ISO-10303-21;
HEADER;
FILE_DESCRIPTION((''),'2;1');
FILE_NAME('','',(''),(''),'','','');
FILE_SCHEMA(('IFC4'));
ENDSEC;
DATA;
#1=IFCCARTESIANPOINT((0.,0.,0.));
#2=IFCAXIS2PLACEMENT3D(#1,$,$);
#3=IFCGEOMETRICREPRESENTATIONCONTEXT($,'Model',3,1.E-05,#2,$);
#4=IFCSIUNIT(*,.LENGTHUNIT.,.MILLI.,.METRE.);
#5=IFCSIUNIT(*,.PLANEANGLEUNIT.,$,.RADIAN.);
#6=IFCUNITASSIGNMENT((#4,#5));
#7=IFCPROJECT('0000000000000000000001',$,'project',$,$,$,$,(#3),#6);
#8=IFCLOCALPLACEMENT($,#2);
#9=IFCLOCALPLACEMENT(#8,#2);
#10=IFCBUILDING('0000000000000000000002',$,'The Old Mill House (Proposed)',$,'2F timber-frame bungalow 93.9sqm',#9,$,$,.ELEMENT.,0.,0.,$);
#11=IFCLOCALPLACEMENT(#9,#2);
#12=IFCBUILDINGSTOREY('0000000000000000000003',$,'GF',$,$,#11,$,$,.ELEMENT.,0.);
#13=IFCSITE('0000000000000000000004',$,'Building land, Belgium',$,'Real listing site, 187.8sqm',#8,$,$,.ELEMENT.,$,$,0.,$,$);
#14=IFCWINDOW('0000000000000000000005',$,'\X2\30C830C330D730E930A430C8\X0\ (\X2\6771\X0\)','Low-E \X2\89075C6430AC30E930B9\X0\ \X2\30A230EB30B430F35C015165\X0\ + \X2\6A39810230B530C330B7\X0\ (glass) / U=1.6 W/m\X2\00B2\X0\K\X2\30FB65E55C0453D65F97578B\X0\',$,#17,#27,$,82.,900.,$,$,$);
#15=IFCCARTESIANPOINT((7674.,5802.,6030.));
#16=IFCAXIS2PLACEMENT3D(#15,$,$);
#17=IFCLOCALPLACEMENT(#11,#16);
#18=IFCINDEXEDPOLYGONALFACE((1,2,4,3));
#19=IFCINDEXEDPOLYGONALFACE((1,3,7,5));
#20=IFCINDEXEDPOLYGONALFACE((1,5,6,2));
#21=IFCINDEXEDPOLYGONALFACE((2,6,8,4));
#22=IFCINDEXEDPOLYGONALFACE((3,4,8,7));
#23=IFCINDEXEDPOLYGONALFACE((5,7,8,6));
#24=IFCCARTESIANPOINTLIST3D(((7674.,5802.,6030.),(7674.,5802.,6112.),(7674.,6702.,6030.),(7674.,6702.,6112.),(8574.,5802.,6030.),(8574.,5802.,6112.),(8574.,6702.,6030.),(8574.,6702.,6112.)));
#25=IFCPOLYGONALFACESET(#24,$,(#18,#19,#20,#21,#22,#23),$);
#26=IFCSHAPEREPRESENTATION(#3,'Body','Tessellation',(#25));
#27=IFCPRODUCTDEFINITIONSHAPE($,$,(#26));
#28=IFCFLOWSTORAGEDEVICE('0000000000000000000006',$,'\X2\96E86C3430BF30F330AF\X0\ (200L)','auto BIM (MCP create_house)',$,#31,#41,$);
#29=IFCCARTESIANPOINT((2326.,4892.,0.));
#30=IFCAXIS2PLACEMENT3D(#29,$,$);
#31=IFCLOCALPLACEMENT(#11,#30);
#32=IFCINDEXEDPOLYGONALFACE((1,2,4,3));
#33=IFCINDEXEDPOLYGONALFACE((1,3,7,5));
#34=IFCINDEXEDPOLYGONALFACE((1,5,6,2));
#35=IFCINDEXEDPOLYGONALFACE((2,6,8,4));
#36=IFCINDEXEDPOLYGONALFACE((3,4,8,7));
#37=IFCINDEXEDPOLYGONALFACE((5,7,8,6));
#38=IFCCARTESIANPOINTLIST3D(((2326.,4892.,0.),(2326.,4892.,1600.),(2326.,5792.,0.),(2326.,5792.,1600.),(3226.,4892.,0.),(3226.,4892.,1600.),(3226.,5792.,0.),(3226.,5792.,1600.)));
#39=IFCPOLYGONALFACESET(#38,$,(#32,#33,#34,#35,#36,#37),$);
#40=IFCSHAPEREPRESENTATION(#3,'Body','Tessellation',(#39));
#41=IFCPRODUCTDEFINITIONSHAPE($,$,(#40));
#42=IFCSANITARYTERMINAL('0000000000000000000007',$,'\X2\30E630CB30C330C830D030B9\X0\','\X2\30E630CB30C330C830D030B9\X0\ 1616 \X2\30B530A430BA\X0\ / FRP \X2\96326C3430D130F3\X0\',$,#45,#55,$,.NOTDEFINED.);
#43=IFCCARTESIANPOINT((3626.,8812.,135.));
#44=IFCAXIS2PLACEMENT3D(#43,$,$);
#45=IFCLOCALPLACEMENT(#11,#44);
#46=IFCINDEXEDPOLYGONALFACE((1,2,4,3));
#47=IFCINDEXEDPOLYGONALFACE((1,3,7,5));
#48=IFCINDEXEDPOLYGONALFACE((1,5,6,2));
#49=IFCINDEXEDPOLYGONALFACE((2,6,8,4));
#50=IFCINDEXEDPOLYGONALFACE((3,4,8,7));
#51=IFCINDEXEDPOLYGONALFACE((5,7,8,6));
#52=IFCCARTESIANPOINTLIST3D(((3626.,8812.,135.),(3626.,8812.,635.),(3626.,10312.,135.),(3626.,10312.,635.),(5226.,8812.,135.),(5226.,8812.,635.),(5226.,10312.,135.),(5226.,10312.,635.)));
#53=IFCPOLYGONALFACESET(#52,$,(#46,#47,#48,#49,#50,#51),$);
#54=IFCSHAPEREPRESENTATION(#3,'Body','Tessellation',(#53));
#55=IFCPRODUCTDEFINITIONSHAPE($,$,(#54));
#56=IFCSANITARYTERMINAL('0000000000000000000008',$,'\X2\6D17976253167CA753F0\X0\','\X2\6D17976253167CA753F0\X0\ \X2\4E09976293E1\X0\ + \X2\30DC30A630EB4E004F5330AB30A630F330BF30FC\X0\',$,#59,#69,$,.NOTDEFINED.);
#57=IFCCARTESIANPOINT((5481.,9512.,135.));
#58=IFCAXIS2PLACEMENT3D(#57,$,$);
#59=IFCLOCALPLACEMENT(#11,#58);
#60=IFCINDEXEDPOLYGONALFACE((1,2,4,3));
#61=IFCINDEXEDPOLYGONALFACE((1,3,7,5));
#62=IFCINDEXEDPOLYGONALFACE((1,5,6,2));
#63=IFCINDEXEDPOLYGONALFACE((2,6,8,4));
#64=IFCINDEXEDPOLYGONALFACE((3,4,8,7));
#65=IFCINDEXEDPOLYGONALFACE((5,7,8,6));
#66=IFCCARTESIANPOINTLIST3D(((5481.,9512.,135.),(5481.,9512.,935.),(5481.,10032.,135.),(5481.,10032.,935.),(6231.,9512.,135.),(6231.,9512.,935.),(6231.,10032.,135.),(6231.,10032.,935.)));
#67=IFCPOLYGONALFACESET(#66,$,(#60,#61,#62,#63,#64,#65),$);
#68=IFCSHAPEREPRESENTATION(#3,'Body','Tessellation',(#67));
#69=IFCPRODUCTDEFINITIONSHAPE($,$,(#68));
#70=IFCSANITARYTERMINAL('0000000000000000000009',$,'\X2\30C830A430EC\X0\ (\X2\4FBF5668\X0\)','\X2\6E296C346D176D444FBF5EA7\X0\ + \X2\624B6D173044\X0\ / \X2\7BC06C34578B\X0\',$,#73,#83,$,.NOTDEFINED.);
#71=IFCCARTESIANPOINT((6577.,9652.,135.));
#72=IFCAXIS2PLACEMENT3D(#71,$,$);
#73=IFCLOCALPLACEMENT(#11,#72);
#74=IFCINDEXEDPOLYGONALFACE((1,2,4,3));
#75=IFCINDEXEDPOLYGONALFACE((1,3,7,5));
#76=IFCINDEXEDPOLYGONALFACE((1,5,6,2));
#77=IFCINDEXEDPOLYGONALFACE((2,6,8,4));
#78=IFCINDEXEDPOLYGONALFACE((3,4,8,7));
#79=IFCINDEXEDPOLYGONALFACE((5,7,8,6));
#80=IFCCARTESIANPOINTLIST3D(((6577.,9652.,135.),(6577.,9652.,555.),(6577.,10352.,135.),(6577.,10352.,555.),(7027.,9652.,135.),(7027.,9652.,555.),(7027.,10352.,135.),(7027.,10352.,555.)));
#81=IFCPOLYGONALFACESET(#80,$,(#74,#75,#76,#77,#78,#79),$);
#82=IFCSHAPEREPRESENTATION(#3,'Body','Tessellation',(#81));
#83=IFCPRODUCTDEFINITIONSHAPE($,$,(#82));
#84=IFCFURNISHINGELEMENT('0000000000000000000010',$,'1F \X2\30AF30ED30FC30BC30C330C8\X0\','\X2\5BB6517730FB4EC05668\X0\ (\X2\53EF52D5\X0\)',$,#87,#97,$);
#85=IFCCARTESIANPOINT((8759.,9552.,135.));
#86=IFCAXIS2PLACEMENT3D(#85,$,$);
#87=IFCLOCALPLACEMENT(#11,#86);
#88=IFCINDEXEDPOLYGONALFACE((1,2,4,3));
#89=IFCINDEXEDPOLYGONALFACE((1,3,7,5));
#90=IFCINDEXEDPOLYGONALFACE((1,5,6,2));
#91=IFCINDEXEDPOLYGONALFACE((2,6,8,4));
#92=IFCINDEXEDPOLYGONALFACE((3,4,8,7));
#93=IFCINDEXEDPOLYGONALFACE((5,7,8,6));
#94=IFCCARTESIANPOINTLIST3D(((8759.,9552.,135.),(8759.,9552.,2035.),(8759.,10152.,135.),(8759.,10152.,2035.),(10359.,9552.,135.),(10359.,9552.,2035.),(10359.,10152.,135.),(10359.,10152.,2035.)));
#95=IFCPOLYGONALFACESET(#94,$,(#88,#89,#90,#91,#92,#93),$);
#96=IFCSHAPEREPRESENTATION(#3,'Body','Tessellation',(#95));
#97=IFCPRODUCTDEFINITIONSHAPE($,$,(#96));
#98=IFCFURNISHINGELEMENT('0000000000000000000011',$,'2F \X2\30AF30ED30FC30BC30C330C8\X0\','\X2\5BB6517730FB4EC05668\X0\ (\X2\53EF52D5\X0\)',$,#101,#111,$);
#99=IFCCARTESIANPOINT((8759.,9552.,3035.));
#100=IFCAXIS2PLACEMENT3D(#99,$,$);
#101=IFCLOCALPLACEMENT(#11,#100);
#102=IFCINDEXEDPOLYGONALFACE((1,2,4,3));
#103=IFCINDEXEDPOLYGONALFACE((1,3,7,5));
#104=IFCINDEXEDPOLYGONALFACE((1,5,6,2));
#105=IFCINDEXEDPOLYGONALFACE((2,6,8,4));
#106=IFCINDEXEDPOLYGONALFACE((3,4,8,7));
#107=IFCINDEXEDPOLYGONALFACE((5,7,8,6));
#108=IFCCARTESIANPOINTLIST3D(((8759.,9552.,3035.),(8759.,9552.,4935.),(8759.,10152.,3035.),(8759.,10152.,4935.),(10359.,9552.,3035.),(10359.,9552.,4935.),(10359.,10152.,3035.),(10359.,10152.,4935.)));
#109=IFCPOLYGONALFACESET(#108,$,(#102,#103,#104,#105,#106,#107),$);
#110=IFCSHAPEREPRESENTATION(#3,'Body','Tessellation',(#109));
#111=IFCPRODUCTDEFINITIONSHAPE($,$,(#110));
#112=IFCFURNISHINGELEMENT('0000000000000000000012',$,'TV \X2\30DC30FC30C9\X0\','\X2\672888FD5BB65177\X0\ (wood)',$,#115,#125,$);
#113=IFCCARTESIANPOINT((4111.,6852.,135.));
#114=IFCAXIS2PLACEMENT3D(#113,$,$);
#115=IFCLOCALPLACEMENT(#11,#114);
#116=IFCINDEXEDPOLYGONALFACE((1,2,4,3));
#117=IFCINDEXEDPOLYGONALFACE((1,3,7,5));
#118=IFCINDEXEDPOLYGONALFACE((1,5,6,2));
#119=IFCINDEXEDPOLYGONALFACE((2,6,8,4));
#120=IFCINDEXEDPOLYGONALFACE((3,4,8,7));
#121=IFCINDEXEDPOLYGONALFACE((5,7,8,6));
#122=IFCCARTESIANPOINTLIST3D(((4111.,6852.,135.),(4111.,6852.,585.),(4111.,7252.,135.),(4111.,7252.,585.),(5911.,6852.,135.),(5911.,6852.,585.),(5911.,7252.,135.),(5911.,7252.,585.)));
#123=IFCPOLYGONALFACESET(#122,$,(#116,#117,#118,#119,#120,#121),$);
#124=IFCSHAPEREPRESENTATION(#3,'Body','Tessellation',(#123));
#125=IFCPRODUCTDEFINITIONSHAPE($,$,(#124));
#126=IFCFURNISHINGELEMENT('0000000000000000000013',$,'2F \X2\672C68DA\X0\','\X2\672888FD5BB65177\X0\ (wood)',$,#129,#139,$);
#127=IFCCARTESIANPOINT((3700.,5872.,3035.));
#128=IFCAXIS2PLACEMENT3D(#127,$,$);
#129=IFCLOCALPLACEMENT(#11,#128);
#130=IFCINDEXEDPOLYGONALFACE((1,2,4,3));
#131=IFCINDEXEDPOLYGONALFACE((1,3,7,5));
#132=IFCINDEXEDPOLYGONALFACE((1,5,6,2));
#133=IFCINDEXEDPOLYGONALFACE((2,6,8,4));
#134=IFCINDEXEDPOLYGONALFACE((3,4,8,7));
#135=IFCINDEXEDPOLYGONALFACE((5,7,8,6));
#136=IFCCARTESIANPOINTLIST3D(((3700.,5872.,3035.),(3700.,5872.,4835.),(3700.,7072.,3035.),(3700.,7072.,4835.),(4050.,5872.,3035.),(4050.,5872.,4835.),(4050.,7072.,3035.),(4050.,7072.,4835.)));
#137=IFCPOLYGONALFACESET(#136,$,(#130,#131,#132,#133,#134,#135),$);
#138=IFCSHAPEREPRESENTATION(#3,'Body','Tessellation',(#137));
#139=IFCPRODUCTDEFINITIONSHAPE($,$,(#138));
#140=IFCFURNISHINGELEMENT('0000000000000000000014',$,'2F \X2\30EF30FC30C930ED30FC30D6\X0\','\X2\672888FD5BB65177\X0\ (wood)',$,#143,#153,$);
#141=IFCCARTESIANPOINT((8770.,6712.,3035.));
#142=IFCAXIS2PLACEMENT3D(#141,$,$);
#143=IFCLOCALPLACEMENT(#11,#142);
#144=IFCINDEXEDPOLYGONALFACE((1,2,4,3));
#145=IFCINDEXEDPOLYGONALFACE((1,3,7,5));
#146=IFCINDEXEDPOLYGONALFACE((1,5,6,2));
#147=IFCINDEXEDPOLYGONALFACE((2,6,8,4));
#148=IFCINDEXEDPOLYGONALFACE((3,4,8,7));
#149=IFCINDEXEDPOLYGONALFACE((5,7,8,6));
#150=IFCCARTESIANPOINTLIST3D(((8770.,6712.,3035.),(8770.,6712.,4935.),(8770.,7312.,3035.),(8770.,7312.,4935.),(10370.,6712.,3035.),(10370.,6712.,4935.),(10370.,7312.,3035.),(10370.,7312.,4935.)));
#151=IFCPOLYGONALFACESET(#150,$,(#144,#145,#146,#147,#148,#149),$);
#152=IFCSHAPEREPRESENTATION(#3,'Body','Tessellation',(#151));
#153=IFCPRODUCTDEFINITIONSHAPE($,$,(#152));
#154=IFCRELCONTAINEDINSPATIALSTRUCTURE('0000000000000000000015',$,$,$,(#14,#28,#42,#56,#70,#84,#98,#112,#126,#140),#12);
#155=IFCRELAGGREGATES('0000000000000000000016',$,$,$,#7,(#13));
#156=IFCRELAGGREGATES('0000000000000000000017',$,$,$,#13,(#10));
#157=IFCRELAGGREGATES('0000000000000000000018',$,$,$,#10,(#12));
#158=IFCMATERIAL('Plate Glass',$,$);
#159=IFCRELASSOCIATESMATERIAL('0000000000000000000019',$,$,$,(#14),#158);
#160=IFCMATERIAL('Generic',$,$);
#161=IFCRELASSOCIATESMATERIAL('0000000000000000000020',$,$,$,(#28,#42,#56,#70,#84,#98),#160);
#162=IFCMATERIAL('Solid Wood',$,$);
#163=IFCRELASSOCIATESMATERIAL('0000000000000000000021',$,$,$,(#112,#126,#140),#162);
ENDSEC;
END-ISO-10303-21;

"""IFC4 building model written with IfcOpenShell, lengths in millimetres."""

from ifc_helpers import new_model, si_unit, frame, frame_2d, origin, place, context, project, spatial, rectangle, extrude, material, element, save


model = new_model("IFC4")

# Units and contexts
model_context = context("Model", 3, precision=1e-05, world=origin())
ifc_project = project(units=[si_unit("LENGTHUNIT", "METRE", prefix="MILLI"), si_unit("PLANEANGLEUNIT", "RADIAN")], contexts=[model_context])

# Site, building, storey
site_placement = place(None, origin())
site = spatial("IfcSite", under=ifc_project, at=site_placement, Name="Building land, Belgium", ObjectType="Real listing site, 187.8sqm", CompositionType="ELEMENT", RefElevation=0.0)
building_placement = place(site_placement, origin())
building = spatial("IfcBuilding", under=site, at=building_placement, Name="The Old Mill House (Proposed)", ObjectType="2F timber-frame bungalow 93.9sqm", CompositionType="ELEMENT", ElevationOfRefHeight=0.0, ElevationOfTerrain=0.0)
storey_placement = place(building_placement, origin())
storey = spatial("IfcBuildingStorey", under=building, at=storey_placement, Name="GF", CompositionType="ELEMENT", Elevation=0.0)

# Shared definitions
ifc_material_1 = material(Name="Solid Wood")
ifc_material_2 = material(Name="Plate Glass")

# Window
window_1_placement = place(storey_placement, frame((7674.0, 5802.0, 6030.0)))
element("IfcWindow", 1, at=window_1_placement, inside=storey, material=ifc_material_2, Name="トップライト (東)", Description="Low-E 複層ガラス アルゴン封入 + 樹脂サッシ (glass) / U=1.6 W/m²K・日射取得型", OverallHeight=82.0, OverallWidth=900.0, context=model_context, shape_type="SweptSolid", body=[
    extrude(rectangle(XDim=900.0, YDim=900.0, at=frame_2d((450.0, 450.0))), frame((7674.0, 5802.0, 6030.0)), (0.0, 0.0, 1.0), 82.0),
])

# Flow storage device
ifc_material_3 = material(Name="Generic")
flow_storage_device_placement = place(storey_placement, frame((2326.0, 4892.0, 0.0)))
element("IfcFlowStorageDevice", 2, at=flow_storage_device_placement, inside=storey, material=ifc_material_3, Name="雨水タンク (200L)", Description="auto BIM (MCP create_house)", context=model_context, shape_type="SweptSolid", body=[
    extrude(rectangle(XDim=900.0, YDim=900.0, at=frame_2d((450.0, 450.0))), frame((2326.0, 4892.0, 0.0)), (0.0, 0.0, 1.0), 1600.0),
])

# Sanitary terminals
sanitary_terminal_1_placement = place(storey_placement, frame((3626.0, 8812.0, 135.0)))
element("IfcSanitaryTerminal", 3, at=sanitary_terminal_1_placement, inside=storey, material=ifc_material_3, Name="ユニットバス", Description="ユニットバス 1616 サイズ / FRP 防水パン", PredefinedType="NOTDEFINED", context=model_context, shape_type="SweptSolid", body=[
    extrude(rectangle(XDim=1600.0, YDim=1500.0, at=frame_2d((800.0, 750.0))), frame((3626.0, 8812.0, 135.0)), (0.0, 0.0, 1.0), 500.0),
])
sanitary_terminal_2_placement = place(storey_placement, frame((5481.0, 9512.0, 135.0)))
element("IfcSanitaryTerminal", 4, at=sanitary_terminal_2_placement, inside=storey, material=ifc_material_3, Name="洗面化粧台", Description="洗面化粧台 三面鏡 + ボウル一体カウンター", PredefinedType="NOTDEFINED", context=model_context, shape_type="SweptSolid", body=[
    extrude(rectangle(XDim=750.0, YDim=520.0, at=frame_2d((375.0, 260.0))), frame((5481.0, 9512.0, 135.0)), (0.0, 0.0, 1.0), 800.0),
])
sanitary_terminal_3_placement = place(storey_placement, frame((6577.0, 9652.0, 135.0)))
element("IfcSanitaryTerminal", 5, at=sanitary_terminal_3_placement, inside=storey, material=ifc_material_3, Name="トイレ (便器)", Description="温水洗浄便座 + 手洗い / 節水型", PredefinedType="NOTDEFINED", context=model_context, shape_type="SweptSolid", body=[
    extrude(rectangle(XDim=450.0, YDim=700.0, at=frame_2d((225.0, 350.0))), frame((6577.0, 9652.0, 135.0)), (0.0, 0.0, 1.0), 420.0),
])

# Furnishing elements
furnishing_1_placement = place(storey_placement, frame((8759.0, 9552.0, 135.0)))
element("IfcFurnishingElement", 6, at=furnishing_1_placement, inside=storey, material=ifc_material_3, Name="1F クローゼット", Description="家具・什器 (可動)", context=model_context, shape_type="SweptSolid", body=[
    extrude(rectangle(XDim=1600.0, YDim=600.0, at=frame_2d((800.0, 300.0))), frame((8759.0, 9552.0, 135.0)), (0.0, 0.0, 1.0), 1900.0),
])
furnishing_2_placement = place(storey_placement, frame((8759.0, 9552.0, 3035.0)))
element("IfcFurnishingElement", 7, at=furnishing_2_placement, inside=storey, material=ifc_material_3, Name="2F クローゼット", Description="家具・什器 (可動)", context=model_context, shape_type="SweptSolid", body=[
    extrude(rectangle(XDim=1600.0, YDim=600.0, at=frame_2d((800.0, 300.0))), frame((8759.0, 9552.0, 3035.0)), (0.0, 0.0, 1.0), 1900.0),
])
furnishing_3_placement = place(storey_placement, frame((4111.0, 6852.0, 135.0)))
element("IfcFurnishingElement", 8, at=furnishing_3_placement, inside=storey, material=ifc_material_1, Name="TV ボード", Description="木製家具 (wood)", context=model_context, shape_type="SweptSolid", body=[
    extrude(rectangle(XDim=1800.0, YDim=400.0, at=frame_2d((900.0, 200.0))), frame((4111.0, 6852.0, 135.0)), (0.0, 0.0, 1.0), 450.0),
])
furnishing_4_placement = place(storey_placement, frame((3700.0, 5872.0, 3035.0)))
element("IfcFurnishingElement", 9, at=furnishing_4_placement, inside=storey, material=ifc_material_1, Name="2F 本棚", Description="木製家具 (wood)", context=model_context, shape_type="SweptSolid", body=[
    extrude(rectangle(XDim=350.0, YDim=1200.0, at=frame_2d((175.0, 600.0))), frame((3700.0, 5872.0, 3035.0)), (0.0, 0.0, 1.0), 1800.0),
])
furnishing_5_placement = place(storey_placement, frame((8770.0, 6712.0, 3035.0)))
element("IfcFurnishingElement", 10, at=furnishing_5_placement, inside=storey, material=ifc_material_1, Name="2F ワードローブ", Description="木製家具 (wood)", context=model_context, shape_type="SweptSolid", body=[
    extrude(rectangle(XDim=1600.0, YDim=600.0, at=frame_2d((800.0, 300.0))), frame((8770.0, 6712.0, 3035.0)), (0.0, 0.0, 1.0), 1900.0),
])

save(model, "model.ifc")
